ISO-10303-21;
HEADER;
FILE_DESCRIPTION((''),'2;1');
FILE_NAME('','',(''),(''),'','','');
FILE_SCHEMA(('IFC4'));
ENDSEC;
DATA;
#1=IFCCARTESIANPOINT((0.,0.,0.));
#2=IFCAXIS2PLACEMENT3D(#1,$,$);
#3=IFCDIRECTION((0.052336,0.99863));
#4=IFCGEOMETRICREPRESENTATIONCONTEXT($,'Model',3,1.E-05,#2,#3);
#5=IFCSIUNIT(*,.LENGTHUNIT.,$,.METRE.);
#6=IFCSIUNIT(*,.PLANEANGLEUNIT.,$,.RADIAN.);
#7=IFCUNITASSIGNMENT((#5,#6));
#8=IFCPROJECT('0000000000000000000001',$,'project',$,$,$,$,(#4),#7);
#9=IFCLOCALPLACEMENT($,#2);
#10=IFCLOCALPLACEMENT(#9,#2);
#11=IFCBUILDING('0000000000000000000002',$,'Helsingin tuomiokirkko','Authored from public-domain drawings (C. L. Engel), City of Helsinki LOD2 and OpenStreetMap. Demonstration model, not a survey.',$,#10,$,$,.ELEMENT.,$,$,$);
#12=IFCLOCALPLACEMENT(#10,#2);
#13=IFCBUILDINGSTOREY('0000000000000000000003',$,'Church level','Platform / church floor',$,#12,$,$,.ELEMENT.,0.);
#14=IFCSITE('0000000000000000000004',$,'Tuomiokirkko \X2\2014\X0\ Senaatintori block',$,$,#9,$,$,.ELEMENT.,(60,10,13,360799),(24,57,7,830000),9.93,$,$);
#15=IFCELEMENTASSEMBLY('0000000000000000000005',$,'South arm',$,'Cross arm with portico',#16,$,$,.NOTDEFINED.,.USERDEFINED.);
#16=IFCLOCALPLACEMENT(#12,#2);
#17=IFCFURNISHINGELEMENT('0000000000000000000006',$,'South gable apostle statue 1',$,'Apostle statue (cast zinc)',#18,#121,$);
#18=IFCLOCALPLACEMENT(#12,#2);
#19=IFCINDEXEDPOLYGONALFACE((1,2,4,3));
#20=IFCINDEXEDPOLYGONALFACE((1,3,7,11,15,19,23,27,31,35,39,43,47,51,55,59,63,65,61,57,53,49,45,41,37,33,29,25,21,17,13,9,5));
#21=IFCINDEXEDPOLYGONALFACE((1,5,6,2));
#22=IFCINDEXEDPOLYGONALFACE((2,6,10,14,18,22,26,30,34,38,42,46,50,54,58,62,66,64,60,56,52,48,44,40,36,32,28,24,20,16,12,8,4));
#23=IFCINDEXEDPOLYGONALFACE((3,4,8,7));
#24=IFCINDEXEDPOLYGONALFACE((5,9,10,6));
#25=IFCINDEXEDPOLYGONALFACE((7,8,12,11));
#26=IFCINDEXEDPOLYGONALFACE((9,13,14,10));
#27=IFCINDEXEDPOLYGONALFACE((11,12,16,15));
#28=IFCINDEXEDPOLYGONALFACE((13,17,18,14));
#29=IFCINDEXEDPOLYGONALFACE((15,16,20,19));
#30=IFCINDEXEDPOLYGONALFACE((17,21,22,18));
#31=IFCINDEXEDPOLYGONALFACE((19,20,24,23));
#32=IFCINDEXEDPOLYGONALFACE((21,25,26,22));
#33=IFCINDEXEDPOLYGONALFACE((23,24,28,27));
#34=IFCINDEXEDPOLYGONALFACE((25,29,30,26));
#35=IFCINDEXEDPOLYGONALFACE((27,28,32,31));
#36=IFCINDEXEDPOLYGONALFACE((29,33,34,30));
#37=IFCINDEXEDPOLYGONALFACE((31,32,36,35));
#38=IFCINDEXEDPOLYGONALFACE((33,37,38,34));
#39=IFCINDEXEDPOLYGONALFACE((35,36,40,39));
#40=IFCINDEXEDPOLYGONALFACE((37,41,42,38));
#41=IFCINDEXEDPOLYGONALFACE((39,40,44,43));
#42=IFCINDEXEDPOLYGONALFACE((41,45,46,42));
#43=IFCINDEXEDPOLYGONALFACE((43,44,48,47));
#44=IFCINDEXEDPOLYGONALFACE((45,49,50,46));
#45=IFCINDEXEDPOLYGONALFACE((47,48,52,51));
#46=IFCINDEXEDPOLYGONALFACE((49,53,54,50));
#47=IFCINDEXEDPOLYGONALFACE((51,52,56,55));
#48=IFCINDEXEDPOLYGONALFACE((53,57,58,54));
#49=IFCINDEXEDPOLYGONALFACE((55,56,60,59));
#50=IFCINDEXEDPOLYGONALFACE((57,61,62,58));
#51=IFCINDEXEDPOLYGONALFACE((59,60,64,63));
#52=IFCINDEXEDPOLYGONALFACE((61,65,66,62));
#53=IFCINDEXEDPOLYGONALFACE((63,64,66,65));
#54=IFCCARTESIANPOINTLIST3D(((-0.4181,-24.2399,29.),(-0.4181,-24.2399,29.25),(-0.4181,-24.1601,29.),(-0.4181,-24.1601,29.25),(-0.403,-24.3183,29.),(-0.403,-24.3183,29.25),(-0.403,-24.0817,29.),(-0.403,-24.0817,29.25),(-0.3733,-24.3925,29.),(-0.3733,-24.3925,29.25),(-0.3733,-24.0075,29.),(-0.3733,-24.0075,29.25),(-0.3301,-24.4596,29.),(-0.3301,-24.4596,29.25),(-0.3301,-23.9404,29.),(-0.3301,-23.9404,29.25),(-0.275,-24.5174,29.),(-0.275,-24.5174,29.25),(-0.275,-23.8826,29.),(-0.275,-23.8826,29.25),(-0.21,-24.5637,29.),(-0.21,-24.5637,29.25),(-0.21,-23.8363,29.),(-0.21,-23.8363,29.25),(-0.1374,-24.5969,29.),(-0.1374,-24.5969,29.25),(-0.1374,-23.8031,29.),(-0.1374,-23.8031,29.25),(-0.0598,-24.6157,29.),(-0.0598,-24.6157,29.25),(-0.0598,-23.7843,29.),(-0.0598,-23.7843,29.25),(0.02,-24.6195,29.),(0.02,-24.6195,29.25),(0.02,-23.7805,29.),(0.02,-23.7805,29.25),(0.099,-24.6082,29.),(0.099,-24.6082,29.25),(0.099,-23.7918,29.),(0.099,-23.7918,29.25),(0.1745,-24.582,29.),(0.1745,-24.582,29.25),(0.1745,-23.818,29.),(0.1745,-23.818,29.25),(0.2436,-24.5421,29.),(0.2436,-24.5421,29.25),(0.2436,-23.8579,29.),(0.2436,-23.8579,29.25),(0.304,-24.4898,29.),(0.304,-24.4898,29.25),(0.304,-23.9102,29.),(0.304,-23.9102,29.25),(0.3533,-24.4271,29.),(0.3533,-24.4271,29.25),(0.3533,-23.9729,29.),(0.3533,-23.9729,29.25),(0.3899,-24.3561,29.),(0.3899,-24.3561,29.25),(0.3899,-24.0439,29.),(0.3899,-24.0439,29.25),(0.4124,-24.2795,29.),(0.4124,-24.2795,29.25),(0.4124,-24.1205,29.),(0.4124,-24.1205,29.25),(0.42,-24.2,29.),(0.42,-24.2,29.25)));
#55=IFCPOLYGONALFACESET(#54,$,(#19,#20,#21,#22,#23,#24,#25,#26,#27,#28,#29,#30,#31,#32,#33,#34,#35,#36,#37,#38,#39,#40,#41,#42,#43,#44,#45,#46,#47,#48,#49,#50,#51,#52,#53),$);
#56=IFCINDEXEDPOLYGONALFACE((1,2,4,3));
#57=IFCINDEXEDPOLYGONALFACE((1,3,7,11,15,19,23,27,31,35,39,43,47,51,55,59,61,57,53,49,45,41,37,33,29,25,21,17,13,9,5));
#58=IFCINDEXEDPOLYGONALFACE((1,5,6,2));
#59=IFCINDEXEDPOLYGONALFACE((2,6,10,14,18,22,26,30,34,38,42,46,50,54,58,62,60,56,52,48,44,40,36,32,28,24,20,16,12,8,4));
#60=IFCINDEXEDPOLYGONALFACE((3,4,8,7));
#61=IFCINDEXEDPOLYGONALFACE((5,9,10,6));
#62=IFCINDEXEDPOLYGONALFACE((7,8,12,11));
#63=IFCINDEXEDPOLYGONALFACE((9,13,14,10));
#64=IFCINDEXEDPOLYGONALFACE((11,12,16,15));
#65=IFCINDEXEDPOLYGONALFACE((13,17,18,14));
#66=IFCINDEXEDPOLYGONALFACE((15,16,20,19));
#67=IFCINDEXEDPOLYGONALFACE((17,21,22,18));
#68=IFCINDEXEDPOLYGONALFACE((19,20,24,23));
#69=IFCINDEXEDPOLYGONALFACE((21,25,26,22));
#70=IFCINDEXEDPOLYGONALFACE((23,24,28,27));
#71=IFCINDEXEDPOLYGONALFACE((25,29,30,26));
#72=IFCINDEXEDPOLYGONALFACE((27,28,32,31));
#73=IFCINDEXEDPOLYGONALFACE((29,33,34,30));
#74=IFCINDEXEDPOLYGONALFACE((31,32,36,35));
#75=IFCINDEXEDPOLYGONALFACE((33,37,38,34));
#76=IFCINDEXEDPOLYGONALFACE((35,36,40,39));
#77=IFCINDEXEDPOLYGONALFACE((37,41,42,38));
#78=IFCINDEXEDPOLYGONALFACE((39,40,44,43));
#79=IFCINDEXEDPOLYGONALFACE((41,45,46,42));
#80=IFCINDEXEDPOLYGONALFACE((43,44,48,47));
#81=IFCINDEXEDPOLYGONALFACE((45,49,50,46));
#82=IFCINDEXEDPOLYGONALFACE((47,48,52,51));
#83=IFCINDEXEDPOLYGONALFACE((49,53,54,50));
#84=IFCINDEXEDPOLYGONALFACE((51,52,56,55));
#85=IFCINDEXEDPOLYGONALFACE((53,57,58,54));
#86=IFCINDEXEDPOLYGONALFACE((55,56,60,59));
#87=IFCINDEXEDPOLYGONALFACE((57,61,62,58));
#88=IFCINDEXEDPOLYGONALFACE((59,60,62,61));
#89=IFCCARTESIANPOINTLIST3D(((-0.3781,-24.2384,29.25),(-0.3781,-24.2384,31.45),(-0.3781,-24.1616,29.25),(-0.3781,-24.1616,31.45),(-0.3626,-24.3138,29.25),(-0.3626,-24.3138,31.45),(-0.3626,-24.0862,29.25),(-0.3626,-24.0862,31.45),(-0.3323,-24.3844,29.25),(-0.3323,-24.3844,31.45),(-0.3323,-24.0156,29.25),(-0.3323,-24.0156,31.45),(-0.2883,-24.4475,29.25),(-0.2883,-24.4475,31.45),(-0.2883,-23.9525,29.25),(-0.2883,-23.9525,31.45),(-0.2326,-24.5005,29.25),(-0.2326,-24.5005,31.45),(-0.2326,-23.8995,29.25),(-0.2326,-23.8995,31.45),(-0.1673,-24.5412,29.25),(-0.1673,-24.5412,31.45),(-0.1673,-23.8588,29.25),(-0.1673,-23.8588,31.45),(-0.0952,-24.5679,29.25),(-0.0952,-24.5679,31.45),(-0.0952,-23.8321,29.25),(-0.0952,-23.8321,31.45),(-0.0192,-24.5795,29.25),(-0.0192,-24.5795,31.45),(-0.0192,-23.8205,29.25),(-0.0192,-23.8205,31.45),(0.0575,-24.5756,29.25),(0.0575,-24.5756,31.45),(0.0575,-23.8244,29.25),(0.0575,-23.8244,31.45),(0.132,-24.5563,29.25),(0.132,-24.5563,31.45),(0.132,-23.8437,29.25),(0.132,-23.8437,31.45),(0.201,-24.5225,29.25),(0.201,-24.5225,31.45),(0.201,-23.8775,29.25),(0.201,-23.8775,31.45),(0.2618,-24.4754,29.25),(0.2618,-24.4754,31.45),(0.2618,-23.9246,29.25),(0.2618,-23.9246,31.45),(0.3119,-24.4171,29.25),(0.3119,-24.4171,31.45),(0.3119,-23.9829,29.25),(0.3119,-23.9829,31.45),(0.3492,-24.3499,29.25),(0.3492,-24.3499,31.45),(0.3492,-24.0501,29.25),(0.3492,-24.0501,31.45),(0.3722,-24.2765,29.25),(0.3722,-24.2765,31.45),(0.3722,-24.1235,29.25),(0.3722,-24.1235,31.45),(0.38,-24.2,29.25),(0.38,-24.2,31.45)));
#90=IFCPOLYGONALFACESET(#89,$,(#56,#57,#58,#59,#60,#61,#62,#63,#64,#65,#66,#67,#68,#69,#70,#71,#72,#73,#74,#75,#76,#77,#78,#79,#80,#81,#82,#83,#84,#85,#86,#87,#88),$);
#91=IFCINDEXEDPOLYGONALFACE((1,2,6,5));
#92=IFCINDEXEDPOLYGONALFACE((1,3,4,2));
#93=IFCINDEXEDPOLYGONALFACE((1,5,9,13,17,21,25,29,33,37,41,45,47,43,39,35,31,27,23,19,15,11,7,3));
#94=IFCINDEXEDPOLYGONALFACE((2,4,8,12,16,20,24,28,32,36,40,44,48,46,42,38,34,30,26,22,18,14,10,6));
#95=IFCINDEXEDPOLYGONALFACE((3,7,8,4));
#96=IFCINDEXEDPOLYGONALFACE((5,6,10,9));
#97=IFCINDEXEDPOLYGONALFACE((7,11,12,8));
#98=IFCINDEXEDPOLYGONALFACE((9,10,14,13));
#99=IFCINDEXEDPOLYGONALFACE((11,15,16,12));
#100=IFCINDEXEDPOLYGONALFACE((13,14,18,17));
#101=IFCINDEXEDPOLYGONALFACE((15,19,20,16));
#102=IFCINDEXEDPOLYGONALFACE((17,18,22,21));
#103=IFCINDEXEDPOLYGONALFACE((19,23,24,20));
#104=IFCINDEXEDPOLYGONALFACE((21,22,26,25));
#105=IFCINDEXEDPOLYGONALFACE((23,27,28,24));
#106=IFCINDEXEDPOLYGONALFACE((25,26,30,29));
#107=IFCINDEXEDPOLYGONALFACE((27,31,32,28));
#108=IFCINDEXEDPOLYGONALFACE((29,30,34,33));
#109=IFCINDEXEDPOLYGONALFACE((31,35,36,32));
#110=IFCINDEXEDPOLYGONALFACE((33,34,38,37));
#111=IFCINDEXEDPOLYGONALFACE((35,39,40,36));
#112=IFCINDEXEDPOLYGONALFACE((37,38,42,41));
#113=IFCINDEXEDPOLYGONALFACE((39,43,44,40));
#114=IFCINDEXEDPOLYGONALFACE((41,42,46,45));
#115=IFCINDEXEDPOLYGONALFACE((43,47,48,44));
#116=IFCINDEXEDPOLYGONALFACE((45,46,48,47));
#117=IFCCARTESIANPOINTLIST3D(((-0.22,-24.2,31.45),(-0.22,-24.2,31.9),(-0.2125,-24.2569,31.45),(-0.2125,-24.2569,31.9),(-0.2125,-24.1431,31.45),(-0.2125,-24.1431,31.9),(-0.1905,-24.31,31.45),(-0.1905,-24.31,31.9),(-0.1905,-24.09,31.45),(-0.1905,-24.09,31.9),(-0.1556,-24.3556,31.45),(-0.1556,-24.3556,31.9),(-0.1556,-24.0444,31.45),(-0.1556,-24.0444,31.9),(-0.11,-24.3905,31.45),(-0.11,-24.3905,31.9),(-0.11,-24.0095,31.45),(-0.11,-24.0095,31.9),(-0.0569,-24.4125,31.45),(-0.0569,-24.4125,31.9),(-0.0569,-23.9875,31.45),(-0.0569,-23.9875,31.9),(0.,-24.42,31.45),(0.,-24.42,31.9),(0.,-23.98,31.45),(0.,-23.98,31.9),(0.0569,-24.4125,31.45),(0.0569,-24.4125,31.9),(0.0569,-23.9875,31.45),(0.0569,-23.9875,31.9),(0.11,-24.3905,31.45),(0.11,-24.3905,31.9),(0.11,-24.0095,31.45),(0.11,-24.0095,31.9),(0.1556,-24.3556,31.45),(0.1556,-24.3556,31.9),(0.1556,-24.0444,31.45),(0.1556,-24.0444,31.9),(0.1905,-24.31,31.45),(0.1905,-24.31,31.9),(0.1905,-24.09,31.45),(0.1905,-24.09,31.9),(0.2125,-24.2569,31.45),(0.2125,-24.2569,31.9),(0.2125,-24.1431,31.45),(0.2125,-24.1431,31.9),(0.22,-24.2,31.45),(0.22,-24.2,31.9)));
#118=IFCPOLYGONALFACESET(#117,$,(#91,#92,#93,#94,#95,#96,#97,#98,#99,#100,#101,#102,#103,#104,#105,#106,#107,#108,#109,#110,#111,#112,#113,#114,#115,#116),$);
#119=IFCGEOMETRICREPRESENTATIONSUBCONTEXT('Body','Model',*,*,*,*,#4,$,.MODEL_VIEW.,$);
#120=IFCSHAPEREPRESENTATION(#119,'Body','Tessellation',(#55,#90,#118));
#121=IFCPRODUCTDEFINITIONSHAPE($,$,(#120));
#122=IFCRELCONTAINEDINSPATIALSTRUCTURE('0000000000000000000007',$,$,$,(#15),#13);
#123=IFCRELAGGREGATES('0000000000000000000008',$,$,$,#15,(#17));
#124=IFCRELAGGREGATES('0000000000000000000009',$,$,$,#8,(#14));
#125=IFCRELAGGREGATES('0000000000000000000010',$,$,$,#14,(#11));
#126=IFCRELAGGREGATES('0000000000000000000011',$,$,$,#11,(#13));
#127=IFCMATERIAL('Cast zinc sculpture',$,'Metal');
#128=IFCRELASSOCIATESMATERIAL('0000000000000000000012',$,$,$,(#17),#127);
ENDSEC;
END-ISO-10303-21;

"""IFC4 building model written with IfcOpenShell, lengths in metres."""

from ifc_helpers import new_model, si_unit, direction, frame, origin, origin_2d_with_axis, place, context, subcontext, project, spatial, circle, extrude, material, element, aggregate, save


model = new_model("IFC4")

# Units and contexts
model_context = context("Model", 3, precision=1e-05, world=origin(), true_north=direction((0.052336, 0.99863)))
body_context = subcontext(model_context, "Body", "Model", "MODEL_VIEW")
ifc_project = project(units=[si_unit("LENGTHUNIT", "METRE"), si_unit("PLANEANGLEUNIT", "RADIAN")], contexts=[model_context])

# Site, building, storey
site_placement = place(None, origin())
site = spatial("IfcSite", under=ifc_project, at=site_placement, Name="Tuomiokirkko — Senaatintori block", CompositionType="ELEMENT", RefLatitude=(60, 10, 13, 360799), RefLongitude=(24, 57, 7, 830000), RefElevation=9.93)
building_placement = place(site_placement, origin())
building = spatial("IfcBuilding", under=site, at=building_placement, Name="Helsingin tuomiokirkko", Description="Authored from public-domain drawings (C. L. Engel), City of Helsinki LOD2 and OpenStreetMap. Demonstration model, not a survey.", CompositionType="ELEMENT")
storey_placement = place(building_placement, origin())
storey = spatial("IfcBuildingStorey", under=building, at=storey_placement, Name="Church level", Description="Platform / church floor", CompositionType="ELEMENT", Elevation=0.0)

# Element assembly
assembly_1_placement = place(building_placement, origin())
assembly_1 = element("IfcElementAssembly", 1, at=assembly_1_placement, inside=storey, Name="South arm", ObjectType="Cross arm with portico", AssemblyPlace="NOTDEFINED", PredefinedType="USERDEFINED")

# Furnishing element
ifc_material_1 = material(Name="Cast zinc sculpture", Category="Metal")
furnishing_1_placement = place(building_placement, origin())
furnishing_1 = element("IfcFurnishingElement", 2, at=furnishing_1_placement, material=ifc_material_1, Name="South gable apostle statue 1", ObjectType="Apostle statue (cast zinc)", context=body_context, shape_type="SweptSolid", body=[
    extrude(circle(Radius=0.42, at=origin_2d_with_axis()), frame((0.0, -24.2, 29.0)), (0.0, 0.0, 1.0), 0.25),
    extrude(circle(Radius=0.38, at=origin_2d_with_axis()), frame((0.0, -24.2, 29.25)), (0.0, 0.0, 1.0), 2.2),
    extrude(circle(Radius=0.22, at=origin_2d_with_axis()), frame((0.0, -24.2, 31.45)), (0.0, 0.0, 1.0), 0.45),
])
aggregate(assembly_1, [furnishing_1])

save(model, "model.ifc")
